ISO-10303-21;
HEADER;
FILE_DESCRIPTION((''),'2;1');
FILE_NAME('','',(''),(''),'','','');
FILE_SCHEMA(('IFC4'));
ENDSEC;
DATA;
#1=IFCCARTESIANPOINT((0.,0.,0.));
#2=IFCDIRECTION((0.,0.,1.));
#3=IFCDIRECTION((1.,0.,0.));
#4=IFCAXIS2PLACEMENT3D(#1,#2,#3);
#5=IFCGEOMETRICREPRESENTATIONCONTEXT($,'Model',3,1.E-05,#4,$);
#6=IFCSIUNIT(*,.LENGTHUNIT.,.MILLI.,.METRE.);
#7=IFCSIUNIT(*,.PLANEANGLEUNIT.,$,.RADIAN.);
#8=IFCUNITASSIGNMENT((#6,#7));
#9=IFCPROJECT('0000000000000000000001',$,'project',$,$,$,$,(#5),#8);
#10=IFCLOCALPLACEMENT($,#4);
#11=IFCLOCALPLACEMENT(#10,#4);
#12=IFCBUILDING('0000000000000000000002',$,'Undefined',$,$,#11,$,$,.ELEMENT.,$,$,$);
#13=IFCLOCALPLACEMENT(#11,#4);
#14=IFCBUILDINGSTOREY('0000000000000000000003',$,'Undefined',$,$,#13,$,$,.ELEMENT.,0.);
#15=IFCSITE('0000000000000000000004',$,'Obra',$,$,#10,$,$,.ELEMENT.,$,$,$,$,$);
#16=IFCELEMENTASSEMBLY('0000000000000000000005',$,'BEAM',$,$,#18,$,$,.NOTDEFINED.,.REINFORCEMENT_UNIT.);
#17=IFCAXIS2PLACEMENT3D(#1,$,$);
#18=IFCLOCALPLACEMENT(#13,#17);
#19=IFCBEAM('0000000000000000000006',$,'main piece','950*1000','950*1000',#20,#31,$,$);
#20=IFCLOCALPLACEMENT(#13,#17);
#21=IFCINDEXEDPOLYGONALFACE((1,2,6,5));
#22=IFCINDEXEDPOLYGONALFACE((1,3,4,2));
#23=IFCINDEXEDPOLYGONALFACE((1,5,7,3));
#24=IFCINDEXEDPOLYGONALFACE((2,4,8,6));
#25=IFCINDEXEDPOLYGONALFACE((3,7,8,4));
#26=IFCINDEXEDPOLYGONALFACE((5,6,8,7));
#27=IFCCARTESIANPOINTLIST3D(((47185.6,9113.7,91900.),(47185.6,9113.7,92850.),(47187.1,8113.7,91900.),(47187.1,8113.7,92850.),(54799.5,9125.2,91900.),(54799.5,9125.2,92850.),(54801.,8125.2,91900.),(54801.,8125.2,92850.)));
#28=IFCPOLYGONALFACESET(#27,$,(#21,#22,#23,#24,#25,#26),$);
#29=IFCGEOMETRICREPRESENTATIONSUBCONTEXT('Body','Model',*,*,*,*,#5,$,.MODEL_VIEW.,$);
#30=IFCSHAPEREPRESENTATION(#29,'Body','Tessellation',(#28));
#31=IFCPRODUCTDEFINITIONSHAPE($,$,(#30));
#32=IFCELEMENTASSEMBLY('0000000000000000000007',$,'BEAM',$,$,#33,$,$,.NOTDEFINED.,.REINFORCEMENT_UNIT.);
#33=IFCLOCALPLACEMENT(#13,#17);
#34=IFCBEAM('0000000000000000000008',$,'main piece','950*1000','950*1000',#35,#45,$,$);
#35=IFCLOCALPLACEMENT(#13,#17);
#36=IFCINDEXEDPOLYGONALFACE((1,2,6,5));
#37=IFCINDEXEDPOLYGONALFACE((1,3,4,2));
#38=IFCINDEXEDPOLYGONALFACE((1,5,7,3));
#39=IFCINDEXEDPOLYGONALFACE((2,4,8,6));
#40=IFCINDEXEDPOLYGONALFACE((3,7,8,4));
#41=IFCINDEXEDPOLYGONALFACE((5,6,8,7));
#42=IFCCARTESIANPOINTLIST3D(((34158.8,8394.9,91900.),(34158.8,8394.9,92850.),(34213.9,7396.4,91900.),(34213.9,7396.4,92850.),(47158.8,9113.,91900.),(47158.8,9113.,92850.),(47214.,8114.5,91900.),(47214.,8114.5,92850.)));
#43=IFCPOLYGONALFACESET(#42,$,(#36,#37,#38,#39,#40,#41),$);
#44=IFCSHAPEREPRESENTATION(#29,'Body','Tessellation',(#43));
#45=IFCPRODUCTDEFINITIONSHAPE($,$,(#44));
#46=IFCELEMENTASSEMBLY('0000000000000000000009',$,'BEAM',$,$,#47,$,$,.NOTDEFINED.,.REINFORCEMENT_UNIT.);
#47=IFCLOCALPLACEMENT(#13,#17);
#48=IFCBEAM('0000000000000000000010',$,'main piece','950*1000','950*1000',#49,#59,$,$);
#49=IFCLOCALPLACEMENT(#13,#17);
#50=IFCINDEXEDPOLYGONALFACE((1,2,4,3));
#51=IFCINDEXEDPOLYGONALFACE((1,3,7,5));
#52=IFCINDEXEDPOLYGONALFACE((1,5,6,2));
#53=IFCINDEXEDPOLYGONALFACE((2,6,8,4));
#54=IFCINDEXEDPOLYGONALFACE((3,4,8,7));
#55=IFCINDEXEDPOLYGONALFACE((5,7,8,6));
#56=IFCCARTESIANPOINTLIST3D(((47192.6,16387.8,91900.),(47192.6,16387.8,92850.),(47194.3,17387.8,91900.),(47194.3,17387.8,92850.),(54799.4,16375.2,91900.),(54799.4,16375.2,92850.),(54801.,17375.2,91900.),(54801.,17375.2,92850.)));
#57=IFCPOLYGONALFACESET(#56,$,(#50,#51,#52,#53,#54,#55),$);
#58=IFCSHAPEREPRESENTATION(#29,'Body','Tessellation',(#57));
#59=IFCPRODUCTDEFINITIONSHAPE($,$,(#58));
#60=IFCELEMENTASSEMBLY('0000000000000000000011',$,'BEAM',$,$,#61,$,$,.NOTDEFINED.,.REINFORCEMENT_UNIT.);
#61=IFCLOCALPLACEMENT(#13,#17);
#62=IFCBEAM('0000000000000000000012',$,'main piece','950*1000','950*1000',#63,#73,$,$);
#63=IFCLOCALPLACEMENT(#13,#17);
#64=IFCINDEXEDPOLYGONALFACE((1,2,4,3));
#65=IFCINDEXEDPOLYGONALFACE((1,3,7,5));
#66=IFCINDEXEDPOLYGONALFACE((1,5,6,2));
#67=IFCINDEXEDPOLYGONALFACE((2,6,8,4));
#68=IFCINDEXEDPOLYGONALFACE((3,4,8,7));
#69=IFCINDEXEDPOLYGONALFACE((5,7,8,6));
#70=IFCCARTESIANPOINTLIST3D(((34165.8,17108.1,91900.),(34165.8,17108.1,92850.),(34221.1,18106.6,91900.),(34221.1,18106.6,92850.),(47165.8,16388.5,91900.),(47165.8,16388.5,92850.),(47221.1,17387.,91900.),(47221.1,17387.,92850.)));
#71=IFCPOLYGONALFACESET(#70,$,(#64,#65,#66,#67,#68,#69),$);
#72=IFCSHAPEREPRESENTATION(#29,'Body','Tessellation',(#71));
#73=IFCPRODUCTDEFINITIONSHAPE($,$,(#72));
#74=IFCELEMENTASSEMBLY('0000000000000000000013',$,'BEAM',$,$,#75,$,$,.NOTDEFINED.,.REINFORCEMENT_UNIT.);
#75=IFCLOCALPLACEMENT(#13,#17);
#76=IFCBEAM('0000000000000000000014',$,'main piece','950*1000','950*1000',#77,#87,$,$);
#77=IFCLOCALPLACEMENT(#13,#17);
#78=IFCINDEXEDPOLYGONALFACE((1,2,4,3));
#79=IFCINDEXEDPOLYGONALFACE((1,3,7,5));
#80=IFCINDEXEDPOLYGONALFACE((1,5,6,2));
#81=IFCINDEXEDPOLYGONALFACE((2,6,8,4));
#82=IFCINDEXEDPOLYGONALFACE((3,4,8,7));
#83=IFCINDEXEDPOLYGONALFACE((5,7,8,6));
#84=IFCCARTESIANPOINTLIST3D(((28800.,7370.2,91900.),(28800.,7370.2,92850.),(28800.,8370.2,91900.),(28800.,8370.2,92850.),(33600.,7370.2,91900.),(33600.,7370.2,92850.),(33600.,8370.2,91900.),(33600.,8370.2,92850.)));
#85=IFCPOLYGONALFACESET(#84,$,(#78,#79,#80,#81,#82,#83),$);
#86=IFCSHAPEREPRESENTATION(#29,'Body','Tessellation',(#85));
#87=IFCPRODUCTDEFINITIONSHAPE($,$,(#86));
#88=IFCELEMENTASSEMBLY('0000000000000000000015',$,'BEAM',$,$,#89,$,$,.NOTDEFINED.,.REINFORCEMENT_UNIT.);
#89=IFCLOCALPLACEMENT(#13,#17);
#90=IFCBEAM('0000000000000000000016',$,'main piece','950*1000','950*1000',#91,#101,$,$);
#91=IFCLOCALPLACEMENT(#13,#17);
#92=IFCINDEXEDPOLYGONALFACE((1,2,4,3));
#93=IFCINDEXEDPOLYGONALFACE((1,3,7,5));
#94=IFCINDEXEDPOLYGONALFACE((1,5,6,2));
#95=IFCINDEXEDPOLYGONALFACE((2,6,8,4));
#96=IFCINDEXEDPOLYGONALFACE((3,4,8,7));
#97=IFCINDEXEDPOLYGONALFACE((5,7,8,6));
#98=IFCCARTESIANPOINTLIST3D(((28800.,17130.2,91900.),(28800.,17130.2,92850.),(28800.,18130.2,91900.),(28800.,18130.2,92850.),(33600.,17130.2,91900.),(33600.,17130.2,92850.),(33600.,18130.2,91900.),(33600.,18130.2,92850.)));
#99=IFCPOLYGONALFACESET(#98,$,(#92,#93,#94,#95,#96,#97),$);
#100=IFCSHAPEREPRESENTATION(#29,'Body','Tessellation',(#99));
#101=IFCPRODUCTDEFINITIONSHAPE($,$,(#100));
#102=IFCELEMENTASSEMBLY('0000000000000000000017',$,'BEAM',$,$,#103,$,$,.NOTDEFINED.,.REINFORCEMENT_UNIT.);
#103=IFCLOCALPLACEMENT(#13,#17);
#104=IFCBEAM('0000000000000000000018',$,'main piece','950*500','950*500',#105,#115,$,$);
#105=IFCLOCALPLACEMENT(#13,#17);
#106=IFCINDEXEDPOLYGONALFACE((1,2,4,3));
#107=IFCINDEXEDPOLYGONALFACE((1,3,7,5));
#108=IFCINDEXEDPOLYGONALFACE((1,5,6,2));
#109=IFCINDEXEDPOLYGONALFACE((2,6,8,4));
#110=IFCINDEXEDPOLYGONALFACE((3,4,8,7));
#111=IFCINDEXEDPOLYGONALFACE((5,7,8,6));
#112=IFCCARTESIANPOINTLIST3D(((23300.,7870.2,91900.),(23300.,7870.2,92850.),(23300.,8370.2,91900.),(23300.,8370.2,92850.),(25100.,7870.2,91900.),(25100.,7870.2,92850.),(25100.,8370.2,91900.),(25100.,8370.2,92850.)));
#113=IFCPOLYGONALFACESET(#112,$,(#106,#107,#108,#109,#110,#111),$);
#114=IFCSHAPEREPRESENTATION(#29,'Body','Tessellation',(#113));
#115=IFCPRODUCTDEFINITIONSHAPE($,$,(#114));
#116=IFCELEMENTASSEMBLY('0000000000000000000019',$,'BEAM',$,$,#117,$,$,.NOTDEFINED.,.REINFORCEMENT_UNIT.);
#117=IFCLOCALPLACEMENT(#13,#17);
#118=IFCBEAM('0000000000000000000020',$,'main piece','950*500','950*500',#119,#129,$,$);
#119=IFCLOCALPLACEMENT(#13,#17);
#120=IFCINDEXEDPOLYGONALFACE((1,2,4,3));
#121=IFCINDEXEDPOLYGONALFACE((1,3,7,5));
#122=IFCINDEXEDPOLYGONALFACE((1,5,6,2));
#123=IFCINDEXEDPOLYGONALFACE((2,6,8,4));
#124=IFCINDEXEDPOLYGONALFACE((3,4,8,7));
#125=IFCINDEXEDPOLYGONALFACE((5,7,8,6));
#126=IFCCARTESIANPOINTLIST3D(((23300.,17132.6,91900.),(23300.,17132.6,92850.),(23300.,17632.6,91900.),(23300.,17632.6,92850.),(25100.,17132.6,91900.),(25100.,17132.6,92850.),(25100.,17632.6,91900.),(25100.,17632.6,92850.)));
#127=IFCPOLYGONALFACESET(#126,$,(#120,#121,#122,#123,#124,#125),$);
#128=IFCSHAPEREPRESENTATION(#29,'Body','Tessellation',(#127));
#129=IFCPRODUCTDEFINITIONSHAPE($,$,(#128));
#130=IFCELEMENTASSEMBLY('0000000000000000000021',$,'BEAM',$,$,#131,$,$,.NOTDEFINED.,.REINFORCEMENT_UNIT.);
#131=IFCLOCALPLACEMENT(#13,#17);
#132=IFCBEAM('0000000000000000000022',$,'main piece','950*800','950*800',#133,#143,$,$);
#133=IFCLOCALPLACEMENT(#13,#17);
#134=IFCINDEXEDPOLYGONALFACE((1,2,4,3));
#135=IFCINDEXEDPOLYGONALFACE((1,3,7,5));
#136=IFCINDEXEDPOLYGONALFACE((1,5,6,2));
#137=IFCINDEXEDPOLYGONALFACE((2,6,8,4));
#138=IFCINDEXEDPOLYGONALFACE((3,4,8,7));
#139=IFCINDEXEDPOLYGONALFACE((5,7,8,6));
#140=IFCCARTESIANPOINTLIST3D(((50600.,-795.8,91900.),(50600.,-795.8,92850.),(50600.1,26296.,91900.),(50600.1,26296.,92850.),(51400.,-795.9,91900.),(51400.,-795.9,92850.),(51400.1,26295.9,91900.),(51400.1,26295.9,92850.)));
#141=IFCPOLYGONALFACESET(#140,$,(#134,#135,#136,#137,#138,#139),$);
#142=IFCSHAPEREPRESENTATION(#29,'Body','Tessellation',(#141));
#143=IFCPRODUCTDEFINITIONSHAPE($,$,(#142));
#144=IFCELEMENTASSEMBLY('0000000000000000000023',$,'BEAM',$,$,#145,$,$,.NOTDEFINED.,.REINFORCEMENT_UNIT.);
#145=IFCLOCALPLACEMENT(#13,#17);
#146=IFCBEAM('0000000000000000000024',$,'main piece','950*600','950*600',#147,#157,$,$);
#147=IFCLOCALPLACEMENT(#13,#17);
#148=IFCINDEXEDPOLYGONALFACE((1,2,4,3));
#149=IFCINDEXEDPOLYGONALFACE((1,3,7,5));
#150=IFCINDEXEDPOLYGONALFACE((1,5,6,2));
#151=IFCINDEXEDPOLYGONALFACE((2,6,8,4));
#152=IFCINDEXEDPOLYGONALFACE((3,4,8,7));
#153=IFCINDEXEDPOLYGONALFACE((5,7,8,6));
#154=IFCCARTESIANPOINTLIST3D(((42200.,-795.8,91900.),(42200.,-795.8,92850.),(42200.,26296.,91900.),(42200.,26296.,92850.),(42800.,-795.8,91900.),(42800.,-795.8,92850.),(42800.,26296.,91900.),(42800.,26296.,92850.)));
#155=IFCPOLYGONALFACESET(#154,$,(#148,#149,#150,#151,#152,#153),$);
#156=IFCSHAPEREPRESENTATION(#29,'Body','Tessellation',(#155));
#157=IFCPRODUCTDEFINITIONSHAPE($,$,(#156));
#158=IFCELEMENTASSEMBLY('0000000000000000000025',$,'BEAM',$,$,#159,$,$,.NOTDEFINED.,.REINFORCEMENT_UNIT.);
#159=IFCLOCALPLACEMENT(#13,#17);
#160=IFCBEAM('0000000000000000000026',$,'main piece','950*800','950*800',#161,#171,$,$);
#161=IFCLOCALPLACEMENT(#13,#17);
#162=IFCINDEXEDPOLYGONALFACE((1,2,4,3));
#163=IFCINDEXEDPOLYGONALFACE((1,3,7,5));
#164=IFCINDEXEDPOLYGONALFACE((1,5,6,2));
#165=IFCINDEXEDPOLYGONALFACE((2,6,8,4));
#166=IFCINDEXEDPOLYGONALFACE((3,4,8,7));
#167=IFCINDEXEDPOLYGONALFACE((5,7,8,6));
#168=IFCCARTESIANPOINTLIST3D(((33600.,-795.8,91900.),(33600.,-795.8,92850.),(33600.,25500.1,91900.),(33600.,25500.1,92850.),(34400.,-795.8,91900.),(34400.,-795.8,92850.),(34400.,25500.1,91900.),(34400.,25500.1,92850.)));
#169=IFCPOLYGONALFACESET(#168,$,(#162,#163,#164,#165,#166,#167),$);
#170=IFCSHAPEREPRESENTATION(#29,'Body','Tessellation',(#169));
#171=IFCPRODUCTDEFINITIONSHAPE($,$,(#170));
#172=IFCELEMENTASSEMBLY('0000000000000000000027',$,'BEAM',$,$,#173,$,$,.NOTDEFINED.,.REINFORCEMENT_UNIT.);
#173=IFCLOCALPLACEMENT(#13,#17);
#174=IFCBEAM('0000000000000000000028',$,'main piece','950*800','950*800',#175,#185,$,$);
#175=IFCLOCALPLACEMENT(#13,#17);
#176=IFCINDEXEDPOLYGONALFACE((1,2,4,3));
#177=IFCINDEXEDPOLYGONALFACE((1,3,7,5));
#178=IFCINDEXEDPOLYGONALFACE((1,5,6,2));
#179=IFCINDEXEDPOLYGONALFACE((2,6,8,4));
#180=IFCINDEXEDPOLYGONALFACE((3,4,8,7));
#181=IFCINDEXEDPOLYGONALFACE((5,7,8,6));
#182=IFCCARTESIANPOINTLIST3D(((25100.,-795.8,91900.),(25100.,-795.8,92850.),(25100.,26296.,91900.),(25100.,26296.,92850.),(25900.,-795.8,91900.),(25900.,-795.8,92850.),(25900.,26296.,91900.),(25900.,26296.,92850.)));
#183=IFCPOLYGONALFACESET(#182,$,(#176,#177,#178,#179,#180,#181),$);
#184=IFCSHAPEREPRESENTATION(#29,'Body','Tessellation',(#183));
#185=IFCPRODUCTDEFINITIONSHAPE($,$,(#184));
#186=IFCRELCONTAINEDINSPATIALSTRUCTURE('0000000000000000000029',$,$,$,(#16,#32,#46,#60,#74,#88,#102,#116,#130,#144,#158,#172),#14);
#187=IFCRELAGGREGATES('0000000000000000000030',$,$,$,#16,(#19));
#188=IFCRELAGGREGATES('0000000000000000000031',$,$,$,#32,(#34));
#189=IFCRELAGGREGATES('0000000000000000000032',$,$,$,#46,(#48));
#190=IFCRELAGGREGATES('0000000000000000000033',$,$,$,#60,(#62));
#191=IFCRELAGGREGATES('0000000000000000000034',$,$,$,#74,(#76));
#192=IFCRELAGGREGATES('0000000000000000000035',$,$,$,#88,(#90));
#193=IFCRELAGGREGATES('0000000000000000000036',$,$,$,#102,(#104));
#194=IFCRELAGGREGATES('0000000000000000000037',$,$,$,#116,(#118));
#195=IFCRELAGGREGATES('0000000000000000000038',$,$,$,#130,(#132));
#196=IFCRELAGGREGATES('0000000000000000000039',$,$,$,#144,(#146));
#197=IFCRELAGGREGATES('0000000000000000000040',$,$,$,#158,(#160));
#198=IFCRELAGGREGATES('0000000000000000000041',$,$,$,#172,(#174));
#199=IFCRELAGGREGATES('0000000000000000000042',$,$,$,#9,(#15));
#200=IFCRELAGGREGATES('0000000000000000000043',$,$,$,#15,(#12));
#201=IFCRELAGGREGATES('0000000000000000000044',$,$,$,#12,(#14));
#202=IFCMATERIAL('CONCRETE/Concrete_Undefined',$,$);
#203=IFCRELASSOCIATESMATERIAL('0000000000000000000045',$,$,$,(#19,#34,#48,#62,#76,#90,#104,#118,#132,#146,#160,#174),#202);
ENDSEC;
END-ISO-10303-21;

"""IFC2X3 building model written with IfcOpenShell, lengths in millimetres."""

from ifc_helpers import new_model, si_unit, frame, origin_with_axes, origin_2d_with_axis, place, context, subcontext, project, spatial, rectangle, extrude, material, element, aggregate, save


model = new_model("IFC2X3")

# Units and contexts
model_context = context("Model", 3, precision=1e-05, world=origin_with_axes())
body_context = subcontext(model_context, "Body", "Model", "MODEL_VIEW")
ifc_project = project(units=[si_unit("LENGTHUNIT", "METRE", prefix="MILLI"), si_unit("PLANEANGLEUNIT", "RADIAN")], contexts=[model_context])

# Site, building, storey
site_placement = place(None, origin_with_axes())
site = spatial("IfcSite", under=ifc_project, at=site_placement, Name="Obra", CompositionType="ELEMENT")
building_placement = place(site_placement, origin_with_axes())
building = spatial("IfcBuilding", under=site, at=building_placement, Name="Undefined", CompositionType="ELEMENT")
storey_placement = place(building_placement, origin_with_axes())
storey = spatial("IfcBuildingStorey", under=building, at=storey_placement, Name="Undefined", CompositionType="ELEMENT", Elevation=0.0)

# Element assemblies, beams
assembly_1_placement = place(storey_placement, origin_with_axes())
assembly_1 = element("IfcElementAssembly", 1, at=assembly_1_placement, inside=storey, Name="BEAM", AssemblyPlace="NOTDEFINED", PredefinedType="REINFORCEMENT_UNIT")
ifc_material_1 = material(Name="CONCRETE/Concrete_Undefined")
beam_1_placement = place(assembly_1_placement, frame((47186.4, 8613.7, 92375.0), z_axis=(0.0, 0.0, 1.0), x_axis=(0.999999, 0.001508, 0.0)))
beam_1 = element("IfcBeam", 2, at=beam_1_placement, material=ifc_material_1, Name="main piece", Description="950*1000", ObjectType="950*1000", context=body_context, shape_type="SweptSolid", body=[
    extrude(rectangle(XDim=1000.0, YDim=950.0, at=origin_2d_with_axis()), frame((7613.8, 0.0, 0.0), z_axis=(-1.0, 0.0, 0.0), x_axis=(0.0, -1.0, 0.0)), (0.0, 0.0, 1.0), 7613.8),
])
aggregate(assembly_1, [beam_1])
assembly_2_placement = place(storey_placement, origin_with_axes())
assembly_2 = element("IfcElementAssembly", 3, at=assembly_2_placement, inside=storey, Name="BEAM", AssemblyPlace="NOTDEFINED", PredefinedType="REINFORCEMENT_UNIT")
beam_2_placement = place(assembly_2_placement, frame((34186.4, 7895.7, 92375.0), z_axis=(0.0, 0.0, 1.0), x_axis=(0.998478, 0.055152, 0.0)))
beam_2 = element("IfcBeam", 4, at=beam_2_placement, material=ifc_material_1, Name="main piece", Description="950*1000", ObjectType="950*1000", context=body_context, shape_type="SweptSolid", body=[
    extrude(rectangle(XDim=1000.0, YDim=950.0, at=origin_2d_with_axis()), frame((13019.8, 0.0, 0.0), z_axis=(-1.0, 0.0, 0.0), x_axis=(0.0, -1.0, 0.0)), (0.0, 0.0, 1.0), 13019.8),
])
aggregate(assembly_2, [beam_2])
assembly_3_placement = place(storey_placement, origin_with_axes())
assembly_3 = element("IfcElementAssembly", 5, at=assembly_3_placement, inside=storey, Name="BEAM", AssemblyPlace="NOTDEFINED", PredefinedType="REINFORCEMENT_UNIT")
beam_3_placement = place(assembly_3_placement, frame((47193.5, 16887.8, 92375.0), z_axis=(0.0, 0.0, 1.0), x_axis=(0.999999, -0.001649, 0.0)))
beam_3 = element("IfcBeam", 6, at=beam_3_placement, material=ifc_material_1, Name="main piece", Description="950*1000", ObjectType="950*1000", context=body_context, shape_type="SweptSolid", body=[
    extrude(rectangle(XDim=1000.0, YDim=950.0, at=origin_2d_with_axis()), frame((7606.8, 0.0, 0.0), z_axis=(-1.0, 0.0, 0.0), x_axis=(0.0, -1.0, 0.0)), (0.0, 0.0, 1.0), 7606.8),
])
aggregate(assembly_3, [beam_3])
assembly_4_placement = place(storey_placement, origin_with_axes())
assembly_4 = element("IfcElementAssembly", 7, at=assembly_4_placement, inside=storey, Name="BEAM", AssemblyPlace="NOTDEFINED", PredefinedType="REINFORCEMENT_UNIT")
beam_4_placement = place(assembly_4_placement, frame((34193.5, 17607.3, 92375.0), z_axis=(0.0, 0.0, 1.0), x_axis=(0.998472, -0.055268, 0.0)))
beam_4 = element("IfcBeam", 8, at=beam_4_placement, material=ifc_material_1, Name="main piece", Description="950*1000", ObjectType="950*1000", context=body_context, shape_type="SweptSolid", body=[
    extrude(rectangle(XDim=1000.0, YDim=950.0, at=origin_2d_with_axis()), frame((13019.9, 0.0, 0.0), z_axis=(-1.0, 0.0, 0.0), x_axis=(0.0, -1.0, 0.0)), (0.0, 0.0, 1.0), 13019.9),
])
aggregate(assembly_4, [beam_4])
assembly_5_placement = place(storey_placement, origin_with_axes())
assembly_5 = element("IfcElementAssembly", 9, at=assembly_5_placement, inside=storey, Name="BEAM", AssemblyPlace="NOTDEFINED", PredefinedType="REINFORCEMENT_UNIT")
beam_5_placement = place(assembly_5_placement, frame((28800.0, 7870.2, 92375.0), z_axis=(0.0, 0.0, 1.0), x_axis=(1.0, 0.000005, 0.0)))
beam_5 = element("IfcBeam", 10, at=beam_5_placement, material=ifc_material_1, Name="main piece", Description="950*1000", ObjectType="950*1000", context=body_context, shape_type="SweptSolid", body=[
    extrude(rectangle(XDim=1000.0, YDim=950.0, at=origin_2d_with_axis()), frame((4800.0, 0.0, 0.0), z_axis=(-1.0, 0.0, 0.0), x_axis=(0.0, -1.0, 0.0)), (0.0, 0.0, 1.0), 4800.0),
])
aggregate(assembly_5, [beam_5])
assembly_6_placement = place(storey_placement, origin_with_axes())
assembly_6 = element("IfcElementAssembly", 11, at=assembly_6_placement, inside=storey, Name="BEAM", AssemblyPlace="NOTDEFINED", PredefinedType="REINFORCEMENT_UNIT")
beam_6_placement = place(assembly_6_placement, frame((28800.0, 17630.2, 92375.0), z_axis=(0.0, 0.0, 1.0), x_axis=(1.0, 0.000001, 0.0)))
beam_6 = element("IfcBeam", 12, at=beam_6_placement, material=ifc_material_1, Name="main piece", Description="950*1000", ObjectType="950*1000", context=body_context, shape_type="SweptSolid", body=[
    extrude(rectangle(XDim=1000.0, YDim=950.0, at=origin_2d_with_axis()), frame((4800.0, 0.0, 0.0), z_axis=(-1.0, 0.0, 0.0), x_axis=(0.0, -1.0, 0.0)), (0.0, 0.0, 1.0), 4800.0),
])
aggregate(assembly_6, [beam_6])
assembly_7_placement = place(storey_placement, origin_with_axes())
assembly_7 = element("IfcElementAssembly", 13, at=assembly_7_placement, inside=storey, Name="BEAM", AssemblyPlace="NOTDEFINED", PredefinedType="REINFORCEMENT_UNIT")
beam_7_placement = place(assembly_7_placement, frame((25100.0, 8120.2, 92375.0), z_axis=(0.0, 0.0, 1.0), x_axis=(-1.0, 0.0, 0.0)))
beam_7 = element("IfcBeam", 14, at=beam_7_placement, material=ifc_material_1, Name="main piece", Description="950*500", ObjectType="950*500", context=body_context, shape_type="SweptSolid", body=[
    extrude(rectangle(XDim=500.0, YDim=950.0, at=origin_2d_with_axis()), frame((1800.0, 0.0, 0.0), z_axis=(-1.0, 0.0, 0.0), x_axis=(0.0, -1.0, 0.0)), (0.0, 0.0, 1.0), 1800.0),
])
aggregate(assembly_7, [beam_7])
assembly_8_placement = place(storey_placement, origin_with_axes())
assembly_8 = element("IfcElementAssembly", 15, at=assembly_8_placement, inside=storey, Name="BEAM", AssemblyPlace="NOTDEFINED", PredefinedType="REINFORCEMENT_UNIT")
beam_8_placement = place(assembly_8_placement, frame((25100.0, 17382.6, 92375.0), z_axis=(0.0, 0.0, 1.0), x_axis=(-1.0, 0.0, 0.0)))
beam_8 = element("IfcBeam", 16, at=beam_8_placement, material=ifc_material_1, Name="main piece", Description="950*500", ObjectType="950*500", context=body_context, shape_type="SweptSolid", body=[
    extrude(rectangle(XDim=500.0, YDim=950.0, at=origin_2d_with_axis()), frame((1800.0, 0.0, 0.0), z_axis=(-1.0, 0.0, 0.0), x_axis=(0.0, -1.0, 0.0)), (0.0, 0.0, 1.0), 1800.0),
])
aggregate(assembly_8, [beam_8])
assembly_9_placement = place(storey_placement, origin_with_axes())
assembly_9 = element("IfcElementAssembly", 17, at=assembly_9_placement, inside=storey, Name="BEAM", AssemblyPlace="NOTDEFINED", PredefinedType="REINFORCEMENT_UNIT")
beam_9_placement = place(assembly_9_placement, frame((51000.0, -795.8, 92375.0), z_axis=(0.0, 0.0, 1.0), x_axis=(0.000003, 1.0, 0.0)))
beam_9 = element("IfcBeam", 18, at=beam_9_placement, material=ifc_material_1, Name="main piece", Description="950*800", ObjectType="950*800", context=body_context, shape_type="SweptSolid", body=[
    extrude(rectangle(XDim=800.0, YDim=950.0, at=origin_2d_with_axis()), frame((27091.8, 0.0, 0.0), z_axis=(-1.0, 0.0, 0.0), x_axis=(0.0, -1.0, 0.0)), (0.0, 0.0, 1.0), 27091.8),
])
aggregate(assembly_9, [beam_9])
assembly_10_placement = place(storey_placement, origin_with_axes())
assembly_10 = element("IfcElementAssembly", 19, at=assembly_10_placement, inside=storey, Name="BEAM", AssemblyPlace="NOTDEFINED", PredefinedType="REINFORCEMENT_UNIT")
beam_10_placement = place(assembly_10_placement, frame((42500.0, -795.8, 92375.0), z_axis=(0.0, 0.0, 1.0), x_axis=(0.0, 1.0, 0.0)))
beam_10 = element("IfcBeam", 20, at=beam_10_placement, material=ifc_material_1, Name="main piece", Description="950*600", ObjectType="950*600", context=body_context, shape_type="SweptSolid", body=[
    extrude(rectangle(XDim=600.0, YDim=950.0, at=origin_2d_with_axis()), frame((27091.8, 0.0, 0.0), z_axis=(-1.0, 0.0, 0.0), x_axis=(0.0, -1.0, 0.0)), (0.0, 0.0, 1.0), 27091.8),
])
aggregate(assembly_10, [beam_10])
assembly_11_placement = place(storey_placement, origin_with_axes())
assembly_11 = element("IfcElementAssembly", 21, at=assembly_11_placement, inside=storey, Name="BEAM", AssemblyPlace="NOTDEFINED", PredefinedType="REINFORCEMENT_UNIT")
beam_11_placement = place(assembly_11_placement, frame((34000.0, -795.8, 92375.0), z_axis=(0.0, 0.0, 1.0), x_axis=(0.0, 1.0, 0.0)))
beam_11 = element("IfcBeam", 22, at=beam_11_placement, material=ifc_material_1, Name="main piece", Description="950*800", ObjectType="950*800", context=body_context, shape_type="SweptSolid", body=[
    extrude(rectangle(XDim=800.0, YDim=950.0, at=origin_2d_with_axis()), frame((26296.0, 0.0, 0.0), z_axis=(-1.0, 0.0, 0.0), x_axis=(0.0, -1.0, 0.0)), (0.0, 0.0, 1.0), 26296.0),
])
aggregate(assembly_11, [beam_11])
assembly_12_placement = place(storey_placement, origin_with_axes())
assembly_12 = element("IfcElementAssembly", 23, at=assembly_12_placement, inside=storey, Name="BEAM", AssemblyPlace="NOTDEFINED", PredefinedType="REINFORCEMENT_UNIT")
beam_12_placement = place(assembly_12_placement, frame((25500.0, -795.8, 92375.0), z_axis=(0.0, 0.0, 1.0), x_axis=(0.0, 1.0, 0.0)))
beam_12 = element("IfcBeam", 24, at=beam_12_placement, material=ifc_material_1, Name="main piece", Description="950*800", ObjectType="950*800", context=body_context, shape_type="SweptSolid", body=[
    extrude(rectangle(XDim=800.0, YDim=950.0, at=origin_2d_with_axis()), frame((27091.8, 0.0, 0.0), z_axis=(-1.0, 0.0, 0.0), x_axis=(0.0, -1.0, 0.0)), (0.0, 0.0, 1.0), 27091.8),
])
aggregate(assembly_12, [beam_12])

save(model, "model.ifc")
